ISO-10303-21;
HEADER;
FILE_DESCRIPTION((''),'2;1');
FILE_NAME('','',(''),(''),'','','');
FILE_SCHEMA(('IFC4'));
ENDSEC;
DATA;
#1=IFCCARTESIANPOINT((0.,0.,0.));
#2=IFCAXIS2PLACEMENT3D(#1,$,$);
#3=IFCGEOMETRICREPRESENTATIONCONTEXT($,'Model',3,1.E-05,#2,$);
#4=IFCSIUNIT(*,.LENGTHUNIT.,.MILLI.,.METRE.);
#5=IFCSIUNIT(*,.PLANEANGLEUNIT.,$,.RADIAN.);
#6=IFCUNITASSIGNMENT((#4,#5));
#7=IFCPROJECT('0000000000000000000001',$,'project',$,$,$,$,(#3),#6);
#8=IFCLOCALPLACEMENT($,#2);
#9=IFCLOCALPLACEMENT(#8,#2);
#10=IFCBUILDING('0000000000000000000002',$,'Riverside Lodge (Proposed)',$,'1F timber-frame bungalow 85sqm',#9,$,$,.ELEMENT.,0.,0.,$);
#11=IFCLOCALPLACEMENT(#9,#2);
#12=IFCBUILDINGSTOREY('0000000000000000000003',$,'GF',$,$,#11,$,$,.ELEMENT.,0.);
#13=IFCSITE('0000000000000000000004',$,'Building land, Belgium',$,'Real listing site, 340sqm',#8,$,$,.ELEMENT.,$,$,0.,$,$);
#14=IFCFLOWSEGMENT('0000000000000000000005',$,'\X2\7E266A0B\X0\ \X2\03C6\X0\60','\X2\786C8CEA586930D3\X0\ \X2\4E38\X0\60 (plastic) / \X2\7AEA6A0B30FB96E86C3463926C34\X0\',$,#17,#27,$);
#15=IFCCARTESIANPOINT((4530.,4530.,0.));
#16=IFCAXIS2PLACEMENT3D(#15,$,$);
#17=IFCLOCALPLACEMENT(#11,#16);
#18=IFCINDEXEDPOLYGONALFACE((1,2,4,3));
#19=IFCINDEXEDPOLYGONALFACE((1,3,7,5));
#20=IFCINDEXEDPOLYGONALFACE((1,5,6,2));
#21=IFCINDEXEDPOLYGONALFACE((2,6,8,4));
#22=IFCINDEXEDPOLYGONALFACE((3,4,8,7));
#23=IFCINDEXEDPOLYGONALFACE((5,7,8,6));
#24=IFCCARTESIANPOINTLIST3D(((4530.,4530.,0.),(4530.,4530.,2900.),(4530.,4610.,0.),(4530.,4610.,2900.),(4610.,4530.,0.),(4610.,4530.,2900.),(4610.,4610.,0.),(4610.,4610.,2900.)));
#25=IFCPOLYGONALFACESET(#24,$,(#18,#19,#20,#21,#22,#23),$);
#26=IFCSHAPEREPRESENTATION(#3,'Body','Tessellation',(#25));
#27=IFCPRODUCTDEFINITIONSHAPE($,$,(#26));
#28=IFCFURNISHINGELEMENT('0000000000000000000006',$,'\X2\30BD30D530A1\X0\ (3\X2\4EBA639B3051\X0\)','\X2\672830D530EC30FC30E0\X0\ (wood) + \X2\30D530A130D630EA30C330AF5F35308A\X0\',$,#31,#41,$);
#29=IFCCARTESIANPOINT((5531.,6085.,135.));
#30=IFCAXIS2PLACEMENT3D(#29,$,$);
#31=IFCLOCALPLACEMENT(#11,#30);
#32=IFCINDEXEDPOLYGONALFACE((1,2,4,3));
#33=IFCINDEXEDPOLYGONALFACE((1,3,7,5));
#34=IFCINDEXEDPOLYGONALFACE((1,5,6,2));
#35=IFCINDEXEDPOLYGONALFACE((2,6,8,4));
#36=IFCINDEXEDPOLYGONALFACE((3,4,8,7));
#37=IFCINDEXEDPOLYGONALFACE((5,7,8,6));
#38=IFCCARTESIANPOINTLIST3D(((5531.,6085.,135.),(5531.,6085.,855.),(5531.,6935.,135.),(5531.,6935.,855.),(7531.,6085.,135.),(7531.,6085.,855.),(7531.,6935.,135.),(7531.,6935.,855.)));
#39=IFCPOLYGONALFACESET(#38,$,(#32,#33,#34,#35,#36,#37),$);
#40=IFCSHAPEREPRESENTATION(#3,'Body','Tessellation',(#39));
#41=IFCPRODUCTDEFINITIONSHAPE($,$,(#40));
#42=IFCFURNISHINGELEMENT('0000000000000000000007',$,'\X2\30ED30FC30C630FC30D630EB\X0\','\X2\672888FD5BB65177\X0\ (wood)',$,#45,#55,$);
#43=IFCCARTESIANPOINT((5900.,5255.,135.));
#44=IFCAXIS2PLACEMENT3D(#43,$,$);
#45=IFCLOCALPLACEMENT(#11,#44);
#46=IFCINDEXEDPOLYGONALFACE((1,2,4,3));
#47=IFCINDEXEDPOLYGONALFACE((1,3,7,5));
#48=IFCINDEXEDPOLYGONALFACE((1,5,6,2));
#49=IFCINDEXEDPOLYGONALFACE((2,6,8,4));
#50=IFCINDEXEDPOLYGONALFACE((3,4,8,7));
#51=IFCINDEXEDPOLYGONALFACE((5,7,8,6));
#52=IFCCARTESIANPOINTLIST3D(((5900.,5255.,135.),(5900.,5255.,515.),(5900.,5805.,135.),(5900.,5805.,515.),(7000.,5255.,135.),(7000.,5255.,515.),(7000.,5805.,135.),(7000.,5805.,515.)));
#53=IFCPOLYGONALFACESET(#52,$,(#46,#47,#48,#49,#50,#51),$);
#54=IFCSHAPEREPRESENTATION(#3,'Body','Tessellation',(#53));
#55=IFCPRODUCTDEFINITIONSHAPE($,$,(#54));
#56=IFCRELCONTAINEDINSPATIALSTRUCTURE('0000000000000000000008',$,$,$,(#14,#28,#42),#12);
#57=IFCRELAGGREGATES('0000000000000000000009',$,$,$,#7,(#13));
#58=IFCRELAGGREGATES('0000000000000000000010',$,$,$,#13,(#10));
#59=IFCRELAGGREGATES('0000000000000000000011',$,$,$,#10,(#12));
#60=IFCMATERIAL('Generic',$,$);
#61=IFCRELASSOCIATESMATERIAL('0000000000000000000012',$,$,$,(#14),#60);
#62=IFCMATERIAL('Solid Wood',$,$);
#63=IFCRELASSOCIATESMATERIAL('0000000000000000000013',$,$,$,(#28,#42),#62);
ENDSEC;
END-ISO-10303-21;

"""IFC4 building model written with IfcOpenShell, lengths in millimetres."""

from ifc_helpers import new_model, si_unit, frame, frame_2d, origin, place, context, project, spatial, rectangle, extrude, material, element, save


model = new_model("IFC4")

# Units and contexts
model_context = context("Model", 3, precision=1e-05, world=origin())
ifc_project = project(units=[si_unit("LENGTHUNIT", "METRE", prefix="MILLI"), si_unit("PLANEANGLEUNIT", "RADIAN")], contexts=[model_context])

# Site, building, storey
site_placement = place(None, origin())
site = spatial("IfcSite", under=ifc_project, at=site_placement, Name="Building land, Belgium", ObjectType="Real listing site, 340sqm", CompositionType="ELEMENT", RefElevation=0.0)
building_placement = place(site_placement, origin())
building = spatial("IfcBuilding", under=site, at=building_placement, Name="Riverside Lodge (Proposed)", ObjectType="1F timber-frame bungalow 85sqm", CompositionType="ELEMENT", ElevationOfRefHeight=0.0, ElevationOfTerrain=0.0)
storey_placement = place(building_placement, origin())
storey = spatial("IfcBuildingStorey", under=building, at=storey_placement, Name="GF", CompositionType="ELEMENT", Elevation=0.0)

# Shared definitions
ifc_material_1 = material(Name="Solid Wood")

# Shared definitions
ifc_material_2 = material(Name="Generic")

# Flow segment
flow_segment_1_placement = place(storey_placement, frame((4530.0, 4530.0, 0.0)))
element("IfcFlowSegment", 1, at=flow_segment_1_placement, inside=storey, material=ifc_material_2, Name="縦樋 φ60", Description="硬質塩ビ 丸60 (plastic) / 竪樋・雨水排水", context=model_context, shape_type="SweptSolid", body=[
    extrude(rectangle(XDim=80.0, YDim=80.0, at=frame_2d((40.0, 40.0))), frame((4530.0, 4530.0, 0.0)), (0.0, 0.0, 1.0), 2900.0),
])

# Furnishing elements
furnishing_1_placement = place(storey_placement, frame((5531.0, 6085.0, 135.0)))
element("IfcFurnishingElement", 2, at=furnishing_1_placement, inside=storey, material=ifc_material_1, Name="ソファ (3人掛け)", Description="木フレーム (wood) + ファブリック張り", context=model_context, shape_type="SweptSolid", body=[
    extrude(rectangle(XDim=2000.0, YDim=850.0, at=frame_2d((1000.0, 425.0))), frame((5531.0, 6085.0, 135.0)), (0.0, 0.0, 1.0), 720.0),
])
furnishing_2_placement = place(storey_placement, frame((5900.0, 5255.0, 135.0)))
element("IfcFurnishingElement", 3, at=furnishing_2_placement, inside=storey, material=ifc_material_1, Name="ローテーブル", Description="木製家具 (wood)", context=model_context, shape_type="SweptSolid", body=[
    extrude(rectangle(XDim=1100.0, YDim=550.0, at=frame_2d((550.0, 275.0))), frame((5900.0, 5255.0, 135.0)), (0.0, 0.0, 1.0), 380.0),
])

save(model, "model.ifc")
